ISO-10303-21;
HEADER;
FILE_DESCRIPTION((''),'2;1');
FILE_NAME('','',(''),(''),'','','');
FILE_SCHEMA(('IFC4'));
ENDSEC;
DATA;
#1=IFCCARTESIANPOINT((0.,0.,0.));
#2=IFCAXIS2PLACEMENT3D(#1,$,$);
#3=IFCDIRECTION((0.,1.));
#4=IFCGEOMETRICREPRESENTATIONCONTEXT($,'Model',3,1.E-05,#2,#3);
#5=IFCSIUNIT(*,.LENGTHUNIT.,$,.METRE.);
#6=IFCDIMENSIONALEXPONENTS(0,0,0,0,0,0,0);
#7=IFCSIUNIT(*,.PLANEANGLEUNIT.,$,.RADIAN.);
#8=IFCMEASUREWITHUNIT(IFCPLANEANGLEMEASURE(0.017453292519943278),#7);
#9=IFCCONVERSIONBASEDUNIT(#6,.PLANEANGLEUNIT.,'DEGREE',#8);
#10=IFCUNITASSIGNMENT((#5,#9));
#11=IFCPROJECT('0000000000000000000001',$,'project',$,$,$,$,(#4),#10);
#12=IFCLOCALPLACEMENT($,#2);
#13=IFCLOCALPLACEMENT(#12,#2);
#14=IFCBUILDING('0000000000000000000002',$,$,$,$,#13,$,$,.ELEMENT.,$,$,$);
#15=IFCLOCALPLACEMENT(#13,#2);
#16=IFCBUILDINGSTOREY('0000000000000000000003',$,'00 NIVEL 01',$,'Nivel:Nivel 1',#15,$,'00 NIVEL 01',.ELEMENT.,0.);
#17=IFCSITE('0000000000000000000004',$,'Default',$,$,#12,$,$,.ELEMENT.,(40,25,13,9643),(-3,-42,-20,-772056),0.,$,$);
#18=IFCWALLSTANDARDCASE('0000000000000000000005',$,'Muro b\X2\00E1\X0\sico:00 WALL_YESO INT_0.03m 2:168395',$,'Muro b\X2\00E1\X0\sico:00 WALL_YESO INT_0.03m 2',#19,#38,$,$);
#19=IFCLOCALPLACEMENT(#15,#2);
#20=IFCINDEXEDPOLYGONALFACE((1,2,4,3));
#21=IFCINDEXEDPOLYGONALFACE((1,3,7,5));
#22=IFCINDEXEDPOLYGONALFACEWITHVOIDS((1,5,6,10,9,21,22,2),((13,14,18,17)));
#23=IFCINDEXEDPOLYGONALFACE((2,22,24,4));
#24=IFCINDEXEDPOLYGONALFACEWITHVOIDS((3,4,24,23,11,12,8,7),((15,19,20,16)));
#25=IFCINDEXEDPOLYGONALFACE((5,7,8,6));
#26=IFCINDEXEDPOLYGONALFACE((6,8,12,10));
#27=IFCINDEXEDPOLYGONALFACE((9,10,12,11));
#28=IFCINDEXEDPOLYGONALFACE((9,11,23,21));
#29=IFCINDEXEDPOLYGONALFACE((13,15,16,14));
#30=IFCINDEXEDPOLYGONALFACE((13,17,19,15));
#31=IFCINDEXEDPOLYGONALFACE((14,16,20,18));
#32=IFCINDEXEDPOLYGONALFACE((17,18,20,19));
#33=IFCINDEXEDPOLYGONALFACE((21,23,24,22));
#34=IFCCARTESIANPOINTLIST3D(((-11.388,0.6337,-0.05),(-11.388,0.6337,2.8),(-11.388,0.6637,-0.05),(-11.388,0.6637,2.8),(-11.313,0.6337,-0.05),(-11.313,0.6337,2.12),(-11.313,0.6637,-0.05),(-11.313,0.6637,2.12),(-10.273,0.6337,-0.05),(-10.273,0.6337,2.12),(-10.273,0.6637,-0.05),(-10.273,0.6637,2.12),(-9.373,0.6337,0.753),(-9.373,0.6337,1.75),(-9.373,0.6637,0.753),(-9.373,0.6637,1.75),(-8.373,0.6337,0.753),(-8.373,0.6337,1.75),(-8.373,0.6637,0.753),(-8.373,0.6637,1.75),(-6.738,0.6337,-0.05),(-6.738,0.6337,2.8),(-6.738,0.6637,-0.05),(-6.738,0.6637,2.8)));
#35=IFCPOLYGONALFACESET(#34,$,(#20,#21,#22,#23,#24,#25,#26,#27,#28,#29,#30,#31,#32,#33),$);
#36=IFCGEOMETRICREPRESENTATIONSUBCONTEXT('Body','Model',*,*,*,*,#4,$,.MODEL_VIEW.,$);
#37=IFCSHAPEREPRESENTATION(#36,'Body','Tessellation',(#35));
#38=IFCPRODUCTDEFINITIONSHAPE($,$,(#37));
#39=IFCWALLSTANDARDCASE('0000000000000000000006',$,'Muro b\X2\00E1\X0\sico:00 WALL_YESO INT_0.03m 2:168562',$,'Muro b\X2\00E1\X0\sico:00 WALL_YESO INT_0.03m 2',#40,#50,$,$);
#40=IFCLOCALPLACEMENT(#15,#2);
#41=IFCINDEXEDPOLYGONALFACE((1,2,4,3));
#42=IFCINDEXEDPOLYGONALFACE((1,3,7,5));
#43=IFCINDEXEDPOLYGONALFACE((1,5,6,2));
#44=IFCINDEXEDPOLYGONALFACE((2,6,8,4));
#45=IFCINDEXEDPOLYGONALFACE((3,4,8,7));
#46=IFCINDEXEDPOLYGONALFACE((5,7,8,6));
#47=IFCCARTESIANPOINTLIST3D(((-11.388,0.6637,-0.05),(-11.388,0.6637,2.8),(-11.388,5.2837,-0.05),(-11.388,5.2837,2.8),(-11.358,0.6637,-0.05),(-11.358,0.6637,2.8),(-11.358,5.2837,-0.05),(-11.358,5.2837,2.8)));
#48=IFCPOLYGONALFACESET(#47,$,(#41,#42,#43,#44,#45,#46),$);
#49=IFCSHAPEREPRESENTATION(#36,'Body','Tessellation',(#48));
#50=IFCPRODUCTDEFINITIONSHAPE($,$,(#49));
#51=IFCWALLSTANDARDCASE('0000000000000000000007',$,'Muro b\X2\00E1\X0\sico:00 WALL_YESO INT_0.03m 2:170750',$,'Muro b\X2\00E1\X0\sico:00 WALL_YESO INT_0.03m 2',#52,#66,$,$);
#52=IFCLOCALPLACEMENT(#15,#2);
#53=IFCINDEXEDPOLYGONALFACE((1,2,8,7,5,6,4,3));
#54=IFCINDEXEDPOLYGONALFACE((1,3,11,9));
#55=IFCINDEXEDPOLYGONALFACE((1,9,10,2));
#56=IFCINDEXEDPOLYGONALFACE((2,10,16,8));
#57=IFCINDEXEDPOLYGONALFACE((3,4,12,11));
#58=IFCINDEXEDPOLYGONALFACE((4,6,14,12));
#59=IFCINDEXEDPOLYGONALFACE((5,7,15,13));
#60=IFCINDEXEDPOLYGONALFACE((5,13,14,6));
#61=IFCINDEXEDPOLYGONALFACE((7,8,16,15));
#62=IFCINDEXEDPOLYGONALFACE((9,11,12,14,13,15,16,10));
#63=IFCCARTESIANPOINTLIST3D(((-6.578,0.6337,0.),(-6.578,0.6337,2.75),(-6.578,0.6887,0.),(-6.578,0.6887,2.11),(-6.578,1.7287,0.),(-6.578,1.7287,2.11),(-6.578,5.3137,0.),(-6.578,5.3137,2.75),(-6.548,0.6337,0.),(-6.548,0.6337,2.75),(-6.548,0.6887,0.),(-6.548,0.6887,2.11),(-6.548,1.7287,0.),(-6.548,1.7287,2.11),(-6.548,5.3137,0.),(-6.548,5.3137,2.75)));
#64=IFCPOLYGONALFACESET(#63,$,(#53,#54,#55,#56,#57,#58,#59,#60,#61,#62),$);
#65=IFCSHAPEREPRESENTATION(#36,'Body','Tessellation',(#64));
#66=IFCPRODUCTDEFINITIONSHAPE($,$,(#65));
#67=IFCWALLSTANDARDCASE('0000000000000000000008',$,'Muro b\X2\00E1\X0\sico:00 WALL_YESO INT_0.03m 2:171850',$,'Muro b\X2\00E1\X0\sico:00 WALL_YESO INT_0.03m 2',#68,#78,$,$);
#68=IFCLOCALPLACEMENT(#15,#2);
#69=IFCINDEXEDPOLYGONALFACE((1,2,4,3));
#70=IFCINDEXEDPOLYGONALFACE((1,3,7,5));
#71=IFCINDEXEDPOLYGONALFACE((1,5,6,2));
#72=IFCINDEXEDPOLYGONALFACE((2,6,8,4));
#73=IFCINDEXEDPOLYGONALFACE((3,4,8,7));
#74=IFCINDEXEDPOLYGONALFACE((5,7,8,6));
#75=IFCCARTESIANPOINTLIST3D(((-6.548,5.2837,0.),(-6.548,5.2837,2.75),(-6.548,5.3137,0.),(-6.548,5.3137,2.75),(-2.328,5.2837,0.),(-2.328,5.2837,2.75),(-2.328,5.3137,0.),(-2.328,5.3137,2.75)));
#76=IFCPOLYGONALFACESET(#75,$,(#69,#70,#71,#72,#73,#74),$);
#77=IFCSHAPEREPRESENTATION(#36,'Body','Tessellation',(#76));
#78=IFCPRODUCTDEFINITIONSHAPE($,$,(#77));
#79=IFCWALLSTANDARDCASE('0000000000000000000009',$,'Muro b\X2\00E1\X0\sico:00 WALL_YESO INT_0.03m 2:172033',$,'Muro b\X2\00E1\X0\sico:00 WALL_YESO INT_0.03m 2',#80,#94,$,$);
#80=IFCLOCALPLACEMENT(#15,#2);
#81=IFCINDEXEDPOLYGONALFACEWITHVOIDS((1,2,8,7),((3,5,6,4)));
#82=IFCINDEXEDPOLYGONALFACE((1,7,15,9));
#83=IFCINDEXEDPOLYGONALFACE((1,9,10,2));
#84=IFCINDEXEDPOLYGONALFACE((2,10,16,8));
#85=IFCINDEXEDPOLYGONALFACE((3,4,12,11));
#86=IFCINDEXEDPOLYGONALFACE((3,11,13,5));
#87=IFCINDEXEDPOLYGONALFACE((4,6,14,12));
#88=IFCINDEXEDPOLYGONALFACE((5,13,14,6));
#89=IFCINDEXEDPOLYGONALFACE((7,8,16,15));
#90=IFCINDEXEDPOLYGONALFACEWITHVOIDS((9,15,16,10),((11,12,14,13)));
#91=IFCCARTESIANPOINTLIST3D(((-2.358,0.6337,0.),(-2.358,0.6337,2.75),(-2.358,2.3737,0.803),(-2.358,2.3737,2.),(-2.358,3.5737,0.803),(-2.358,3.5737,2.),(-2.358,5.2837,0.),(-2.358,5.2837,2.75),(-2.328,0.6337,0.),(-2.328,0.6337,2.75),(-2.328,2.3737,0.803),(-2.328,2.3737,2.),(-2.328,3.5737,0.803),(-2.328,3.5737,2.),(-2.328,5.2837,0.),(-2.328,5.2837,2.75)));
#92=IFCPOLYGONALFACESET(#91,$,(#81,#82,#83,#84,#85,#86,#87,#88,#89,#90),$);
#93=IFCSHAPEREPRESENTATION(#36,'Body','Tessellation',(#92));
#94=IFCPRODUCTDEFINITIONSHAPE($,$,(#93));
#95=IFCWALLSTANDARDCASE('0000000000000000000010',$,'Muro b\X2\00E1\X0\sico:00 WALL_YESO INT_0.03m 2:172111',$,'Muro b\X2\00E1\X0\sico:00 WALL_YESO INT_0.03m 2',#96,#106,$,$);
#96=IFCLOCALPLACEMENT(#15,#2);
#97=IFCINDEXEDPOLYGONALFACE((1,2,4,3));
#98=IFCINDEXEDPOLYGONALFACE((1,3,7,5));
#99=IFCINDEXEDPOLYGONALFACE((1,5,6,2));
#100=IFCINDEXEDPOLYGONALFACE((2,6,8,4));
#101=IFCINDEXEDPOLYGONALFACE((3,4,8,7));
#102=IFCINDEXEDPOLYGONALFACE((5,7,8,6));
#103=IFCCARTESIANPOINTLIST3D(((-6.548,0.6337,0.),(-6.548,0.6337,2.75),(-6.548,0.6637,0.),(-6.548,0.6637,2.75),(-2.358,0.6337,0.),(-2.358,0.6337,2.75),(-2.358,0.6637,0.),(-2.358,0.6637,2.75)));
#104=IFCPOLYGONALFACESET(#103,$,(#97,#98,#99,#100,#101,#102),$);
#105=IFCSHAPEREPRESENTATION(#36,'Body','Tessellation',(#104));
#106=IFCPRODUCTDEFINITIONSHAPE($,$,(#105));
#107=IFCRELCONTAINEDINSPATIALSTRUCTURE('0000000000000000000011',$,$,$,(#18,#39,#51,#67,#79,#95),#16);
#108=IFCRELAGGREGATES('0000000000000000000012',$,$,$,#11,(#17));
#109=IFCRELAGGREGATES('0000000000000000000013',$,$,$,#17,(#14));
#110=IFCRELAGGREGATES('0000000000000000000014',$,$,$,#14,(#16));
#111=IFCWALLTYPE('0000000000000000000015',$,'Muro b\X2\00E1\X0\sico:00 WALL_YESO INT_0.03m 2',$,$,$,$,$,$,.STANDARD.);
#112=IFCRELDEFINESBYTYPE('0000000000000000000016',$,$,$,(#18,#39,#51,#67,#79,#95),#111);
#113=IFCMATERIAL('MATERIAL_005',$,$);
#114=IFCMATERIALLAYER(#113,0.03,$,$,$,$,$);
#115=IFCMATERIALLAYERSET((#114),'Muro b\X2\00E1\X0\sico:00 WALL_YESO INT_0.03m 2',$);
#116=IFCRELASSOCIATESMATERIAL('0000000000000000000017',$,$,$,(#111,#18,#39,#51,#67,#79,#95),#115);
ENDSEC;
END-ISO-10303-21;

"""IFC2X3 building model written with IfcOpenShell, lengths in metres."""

from ifc_helpers import new_model, entity, si_unit, converted_unit, direction, frame, frame_2d, origin, place, context, subcontext, project, spatial, rectangle, extrude, material, layer, layer_set, layer_usage, type_object, element, save


model = new_model("IFC2X3")

# Units and contexts
model_context = context("Model", 3, precision=1e-05, world=origin(), true_north=direction((0.0, 1.0)))
body_context = subcontext(model_context, "Body", "Model", "MODEL_VIEW")
ifc_project = project(units=[si_unit("LENGTHUNIT", "METRE"), converted_unit("PLANEANGLEUNIT", "DEGREE", entity("IfcPlaneAngleMeasure", 0.017453292519943278), si_unit("PLANEANGLEUNIT", "RADIAN"), dimensions=[0, 0, 0, 0, 0, 0, 0])], contexts=[model_context])

# Site, building, storey
site_placement = place(None, origin())
site = spatial("IfcSite", under=ifc_project, at=site_placement, Name="Default", CompositionType="ELEMENT", RefLatitude=(40, 25, 13, 9643), RefLongitude=(-3, -42, -20, -772056), RefElevation=0.0)
building_placement = place(site_placement, origin())
building = spatial("IfcBuilding", under=site, at=building_placement, CompositionType="ELEMENT")
storey_placement = place(building_placement, origin())
storey = spatial("IfcBuildingStorey", under=building, at=storey_placement, Name="00 NIVEL 01", ObjectType="Nivel:Nivel 1", LongName="00 NIVEL 01", CompositionType="ELEMENT", Elevation=0.0)

# Shared definitions
ifc_material_1 = material(Name="MATERIAL_005")
ifc_layer_1 = layer(ifc_material_1, 0.03)
ifc_layer_set_1 = layer_set([ifc_layer_1], Name="Muro básico:00 WALL_YESO INT_0.03m 2")
wall_type_1 = type_object("IfcWallType", Name="Muro básico:00 WALL_YESO INT_0.03m 2", PredefinedType="STANDARD", material=ifc_layer_set_1)

# Wall, openings
ifc_layer_usage_1 = layer_usage(ifc_layer_set_1, "AXIS2", "NEGATIVE", 0.015)
wall_1_placement = place(storey_placement, frame((-6.738, 0.6487, -0.05), z_axis=(0.0, 0.0, 1.0), x_axis=(-1.0, 0.0, 0.0)))
wall_1 = element("IfcWallStandardCase", 1, at=wall_1_placement, inside=storey, type_object=wall_type_1, material=ifc_layer_usage_1, Name="Muro básico:00 WALL_YESO INT_0.03m 2:168395", ObjectType="Muro básico:00 WALL_YESO INT_0.03m 2", context=body_context, shape_type="SweptSolid", body=[
    extrude(rectangle(XDim=4.65, YDim=0.03, at=frame_2d((2.325, 0.0), x_axis=(-1.0, 0.0))), origin(), (0.0, 0.0, 1.0), 2.85),
])
opening_1_placement = place(wall_1_placement, origin())
element("IfcOpeningElement", 2, at=opening_1_placement, cuts=wall_1, ObjectType="Opening", context=body_context, shape_type="SweptSolid", body=[
    extrude(rectangle(XDim=0.997, YDim=1.0, at=frame_2d((0.0, 0.0), x_axis=(0.0, 1.0))), frame((2.135, 0.015, 1.3015), z_axis=(0.0, -1.0, 0.0), x_axis=(1.0, 0.0, 0.0)), (0.0, 0.0, 1.0), 0.03),
])
opening_2_placement = place(wall_1_placement, origin())
element("IfcOpeningElement", 3, at=opening_2_placement, cuts=wall_1, ObjectType="Opening", context=body_context, shape_type="SweptSolid", body=[
    extrude(rectangle(XDim=2.17, YDim=1.04, at=frame_2d((0.0, 0.0), x_axis=(0.0, 1.0))), frame((4.055, 0.015, 1.085), z_axis=(0.0, -1.0, 0.0), x_axis=(1.0, 0.0, 0.0)), (0.0, 0.0, 1.0), 0.03),
])

# Wall
ifc_layer_usage_2 = layer_usage(ifc_layer_set_1, "AXIS2", "NEGATIVE", 0.015)
wall_2_placement = place(storey_placement, frame((-11.373, 0.6637, -0.05), z_axis=(0.0, 0.0, 1.0), x_axis=(0.0, 1.0, 0.0)))
element("IfcWallStandardCase", 4, at=wall_2_placement, inside=storey, type_object=wall_type_1, material=ifc_layer_usage_2, Name="Muro básico:00 WALL_YESO INT_0.03m 2:168562", ObjectType="Muro básico:00 WALL_YESO INT_0.03m 2", context=body_context, shape_type="SweptSolid", body=[
    extrude(rectangle(XDim=4.62, YDim=0.03, at=frame_2d((2.31, 0.0), x_axis=(-1.0, 0.0))), origin(), (0.0, 0.0, 1.0), 2.85),
])

# Wall, opening
ifc_layer_usage_3 = layer_usage(ifc_layer_set_1, "AXIS2", "POSITIVE", -0.015)
wall_3_placement = place(storey_placement, frame((-6.563, 5.3137, 0.0), z_axis=(0.0, 0.0, 1.0), x_axis=(0.0, -1.0, 0.0)))
wall_3 = element("IfcWallStandardCase", 5, at=wall_3_placement, inside=storey, type_object=wall_type_1, material=ifc_layer_usage_3, Name="Muro básico:00 WALL_YESO INT_0.03m 2:170750", ObjectType="Muro básico:00 WALL_YESO INT_0.03m 2", context=body_context, shape_type="SweptSolid", body=[
    extrude(rectangle(XDim=4.68, YDim=0.03, at=frame_2d((2.34, 0.0), x_axis=(-1.0, 0.0))), origin(), (0.0, 0.0, 1.0), 2.75),
])
opening_3_placement = place(wall_3_placement, origin())
element("IfcOpeningElement", 6, at=opening_3_placement, cuts=wall_3, ObjectType="Opening", context=body_context, shape_type="SweptSolid", body=[
    extrude(rectangle(XDim=2.11, YDim=1.04, at=frame_2d((0.0, 0.0), x_axis=(0.0, 1.0))), frame((4.105, 0.015, 1.055), z_axis=(0.0, -1.0, 0.0), x_axis=(1.0, 0.0, 0.0)), (0.0, 0.0, 1.0), 0.03),
])

# Wall
ifc_layer_usage_4 = layer_usage(ifc_layer_set_1, "AXIS2", "NEGATIVE", 0.015)
wall_4_placement = place(storey_placement, frame((-6.548, 5.2987, 0.0)))
element("IfcWallStandardCase", 7, at=wall_4_placement, inside=storey, type_object=wall_type_1, material=ifc_layer_usage_4, Name="Muro básico:00 WALL_YESO INT_0.03m 2:171850", ObjectType="Muro básico:00 WALL_YESO INT_0.03m 2", context=body_context, shape_type="SweptSolid", body=[
    extrude(rectangle(XDim=4.22, YDim=0.03, at=frame_2d((2.11, 0.0), x_axis=(-1.0, 0.0))), origin(), (0.0, 0.0, 1.0), 2.75),
])

# Wall, opening
ifc_layer_usage_5 = layer_usage(ifc_layer_set_1, "AXIS2", "NEGATIVE", 0.015)
wall_5_placement = place(storey_placement, frame((-2.343, 5.2837, 0.0), z_axis=(0.0, 0.0, 1.0), x_axis=(0.0, -1.0, 0.0)))
wall_5 = element("IfcWallStandardCase", 8, at=wall_5_placement, inside=storey, type_object=wall_type_1, material=ifc_layer_usage_5, Name="Muro básico:00 WALL_YESO INT_0.03m 2:172033", ObjectType="Muro básico:00 WALL_YESO INT_0.03m 2", context=body_context, shape_type="SweptSolid", body=[
    extrude(rectangle(XDim=4.65, YDim=0.03, at=frame_2d((2.325, 0.0), x_axis=(-1.0, 0.0))), origin(), (0.0, 0.0, 1.0), 2.75),
])
opening_4_placement = place(wall_5_placement, origin())
element("IfcOpeningElement", 9, at=opening_4_placement, cuts=wall_5, ObjectType="Opening", context=body_context, shape_type="SweptSolid", body=[
    extrude(rectangle(XDim=1.197, YDim=1.2, at=frame_2d((0.0, 0.0), x_axis=(0.0, -1.0))), frame((2.31, 0.015, 1.4015), z_axis=(0.0, 1.0, 0.0), x_axis=(1.0, 0.0, 0.0)), (0.0, 0.0, -1.0), 0.03),
])

# Wall
ifc_layer_usage_6 = layer_usage(ifc_layer_set_1, "AXIS2", "NEGATIVE", 0.015)
wall_6_placement = place(storey_placement, frame((-2.358, 0.6487, 0.0), z_axis=(0.0, 0.0, 1.0), x_axis=(-1.0, 0.0, 0.0)))
element("IfcWallStandardCase", 10, at=wall_6_placement, inside=storey, type_object=wall_type_1, material=ifc_layer_usage_6, Name="Muro básico:00 WALL_YESO INT_0.03m 2:172111", ObjectType="Muro básico:00 WALL_YESO INT_0.03m 2", context=body_context, shape_type="SweptSolid", body=[
    extrude(rectangle(XDim=4.19, YDim=0.03, at=frame_2d((2.095, 0.0), x_axis=(-1.0, 0.0))), origin(), (0.0, 0.0, 1.0), 2.75),
])

save(model, "model.ifc")
